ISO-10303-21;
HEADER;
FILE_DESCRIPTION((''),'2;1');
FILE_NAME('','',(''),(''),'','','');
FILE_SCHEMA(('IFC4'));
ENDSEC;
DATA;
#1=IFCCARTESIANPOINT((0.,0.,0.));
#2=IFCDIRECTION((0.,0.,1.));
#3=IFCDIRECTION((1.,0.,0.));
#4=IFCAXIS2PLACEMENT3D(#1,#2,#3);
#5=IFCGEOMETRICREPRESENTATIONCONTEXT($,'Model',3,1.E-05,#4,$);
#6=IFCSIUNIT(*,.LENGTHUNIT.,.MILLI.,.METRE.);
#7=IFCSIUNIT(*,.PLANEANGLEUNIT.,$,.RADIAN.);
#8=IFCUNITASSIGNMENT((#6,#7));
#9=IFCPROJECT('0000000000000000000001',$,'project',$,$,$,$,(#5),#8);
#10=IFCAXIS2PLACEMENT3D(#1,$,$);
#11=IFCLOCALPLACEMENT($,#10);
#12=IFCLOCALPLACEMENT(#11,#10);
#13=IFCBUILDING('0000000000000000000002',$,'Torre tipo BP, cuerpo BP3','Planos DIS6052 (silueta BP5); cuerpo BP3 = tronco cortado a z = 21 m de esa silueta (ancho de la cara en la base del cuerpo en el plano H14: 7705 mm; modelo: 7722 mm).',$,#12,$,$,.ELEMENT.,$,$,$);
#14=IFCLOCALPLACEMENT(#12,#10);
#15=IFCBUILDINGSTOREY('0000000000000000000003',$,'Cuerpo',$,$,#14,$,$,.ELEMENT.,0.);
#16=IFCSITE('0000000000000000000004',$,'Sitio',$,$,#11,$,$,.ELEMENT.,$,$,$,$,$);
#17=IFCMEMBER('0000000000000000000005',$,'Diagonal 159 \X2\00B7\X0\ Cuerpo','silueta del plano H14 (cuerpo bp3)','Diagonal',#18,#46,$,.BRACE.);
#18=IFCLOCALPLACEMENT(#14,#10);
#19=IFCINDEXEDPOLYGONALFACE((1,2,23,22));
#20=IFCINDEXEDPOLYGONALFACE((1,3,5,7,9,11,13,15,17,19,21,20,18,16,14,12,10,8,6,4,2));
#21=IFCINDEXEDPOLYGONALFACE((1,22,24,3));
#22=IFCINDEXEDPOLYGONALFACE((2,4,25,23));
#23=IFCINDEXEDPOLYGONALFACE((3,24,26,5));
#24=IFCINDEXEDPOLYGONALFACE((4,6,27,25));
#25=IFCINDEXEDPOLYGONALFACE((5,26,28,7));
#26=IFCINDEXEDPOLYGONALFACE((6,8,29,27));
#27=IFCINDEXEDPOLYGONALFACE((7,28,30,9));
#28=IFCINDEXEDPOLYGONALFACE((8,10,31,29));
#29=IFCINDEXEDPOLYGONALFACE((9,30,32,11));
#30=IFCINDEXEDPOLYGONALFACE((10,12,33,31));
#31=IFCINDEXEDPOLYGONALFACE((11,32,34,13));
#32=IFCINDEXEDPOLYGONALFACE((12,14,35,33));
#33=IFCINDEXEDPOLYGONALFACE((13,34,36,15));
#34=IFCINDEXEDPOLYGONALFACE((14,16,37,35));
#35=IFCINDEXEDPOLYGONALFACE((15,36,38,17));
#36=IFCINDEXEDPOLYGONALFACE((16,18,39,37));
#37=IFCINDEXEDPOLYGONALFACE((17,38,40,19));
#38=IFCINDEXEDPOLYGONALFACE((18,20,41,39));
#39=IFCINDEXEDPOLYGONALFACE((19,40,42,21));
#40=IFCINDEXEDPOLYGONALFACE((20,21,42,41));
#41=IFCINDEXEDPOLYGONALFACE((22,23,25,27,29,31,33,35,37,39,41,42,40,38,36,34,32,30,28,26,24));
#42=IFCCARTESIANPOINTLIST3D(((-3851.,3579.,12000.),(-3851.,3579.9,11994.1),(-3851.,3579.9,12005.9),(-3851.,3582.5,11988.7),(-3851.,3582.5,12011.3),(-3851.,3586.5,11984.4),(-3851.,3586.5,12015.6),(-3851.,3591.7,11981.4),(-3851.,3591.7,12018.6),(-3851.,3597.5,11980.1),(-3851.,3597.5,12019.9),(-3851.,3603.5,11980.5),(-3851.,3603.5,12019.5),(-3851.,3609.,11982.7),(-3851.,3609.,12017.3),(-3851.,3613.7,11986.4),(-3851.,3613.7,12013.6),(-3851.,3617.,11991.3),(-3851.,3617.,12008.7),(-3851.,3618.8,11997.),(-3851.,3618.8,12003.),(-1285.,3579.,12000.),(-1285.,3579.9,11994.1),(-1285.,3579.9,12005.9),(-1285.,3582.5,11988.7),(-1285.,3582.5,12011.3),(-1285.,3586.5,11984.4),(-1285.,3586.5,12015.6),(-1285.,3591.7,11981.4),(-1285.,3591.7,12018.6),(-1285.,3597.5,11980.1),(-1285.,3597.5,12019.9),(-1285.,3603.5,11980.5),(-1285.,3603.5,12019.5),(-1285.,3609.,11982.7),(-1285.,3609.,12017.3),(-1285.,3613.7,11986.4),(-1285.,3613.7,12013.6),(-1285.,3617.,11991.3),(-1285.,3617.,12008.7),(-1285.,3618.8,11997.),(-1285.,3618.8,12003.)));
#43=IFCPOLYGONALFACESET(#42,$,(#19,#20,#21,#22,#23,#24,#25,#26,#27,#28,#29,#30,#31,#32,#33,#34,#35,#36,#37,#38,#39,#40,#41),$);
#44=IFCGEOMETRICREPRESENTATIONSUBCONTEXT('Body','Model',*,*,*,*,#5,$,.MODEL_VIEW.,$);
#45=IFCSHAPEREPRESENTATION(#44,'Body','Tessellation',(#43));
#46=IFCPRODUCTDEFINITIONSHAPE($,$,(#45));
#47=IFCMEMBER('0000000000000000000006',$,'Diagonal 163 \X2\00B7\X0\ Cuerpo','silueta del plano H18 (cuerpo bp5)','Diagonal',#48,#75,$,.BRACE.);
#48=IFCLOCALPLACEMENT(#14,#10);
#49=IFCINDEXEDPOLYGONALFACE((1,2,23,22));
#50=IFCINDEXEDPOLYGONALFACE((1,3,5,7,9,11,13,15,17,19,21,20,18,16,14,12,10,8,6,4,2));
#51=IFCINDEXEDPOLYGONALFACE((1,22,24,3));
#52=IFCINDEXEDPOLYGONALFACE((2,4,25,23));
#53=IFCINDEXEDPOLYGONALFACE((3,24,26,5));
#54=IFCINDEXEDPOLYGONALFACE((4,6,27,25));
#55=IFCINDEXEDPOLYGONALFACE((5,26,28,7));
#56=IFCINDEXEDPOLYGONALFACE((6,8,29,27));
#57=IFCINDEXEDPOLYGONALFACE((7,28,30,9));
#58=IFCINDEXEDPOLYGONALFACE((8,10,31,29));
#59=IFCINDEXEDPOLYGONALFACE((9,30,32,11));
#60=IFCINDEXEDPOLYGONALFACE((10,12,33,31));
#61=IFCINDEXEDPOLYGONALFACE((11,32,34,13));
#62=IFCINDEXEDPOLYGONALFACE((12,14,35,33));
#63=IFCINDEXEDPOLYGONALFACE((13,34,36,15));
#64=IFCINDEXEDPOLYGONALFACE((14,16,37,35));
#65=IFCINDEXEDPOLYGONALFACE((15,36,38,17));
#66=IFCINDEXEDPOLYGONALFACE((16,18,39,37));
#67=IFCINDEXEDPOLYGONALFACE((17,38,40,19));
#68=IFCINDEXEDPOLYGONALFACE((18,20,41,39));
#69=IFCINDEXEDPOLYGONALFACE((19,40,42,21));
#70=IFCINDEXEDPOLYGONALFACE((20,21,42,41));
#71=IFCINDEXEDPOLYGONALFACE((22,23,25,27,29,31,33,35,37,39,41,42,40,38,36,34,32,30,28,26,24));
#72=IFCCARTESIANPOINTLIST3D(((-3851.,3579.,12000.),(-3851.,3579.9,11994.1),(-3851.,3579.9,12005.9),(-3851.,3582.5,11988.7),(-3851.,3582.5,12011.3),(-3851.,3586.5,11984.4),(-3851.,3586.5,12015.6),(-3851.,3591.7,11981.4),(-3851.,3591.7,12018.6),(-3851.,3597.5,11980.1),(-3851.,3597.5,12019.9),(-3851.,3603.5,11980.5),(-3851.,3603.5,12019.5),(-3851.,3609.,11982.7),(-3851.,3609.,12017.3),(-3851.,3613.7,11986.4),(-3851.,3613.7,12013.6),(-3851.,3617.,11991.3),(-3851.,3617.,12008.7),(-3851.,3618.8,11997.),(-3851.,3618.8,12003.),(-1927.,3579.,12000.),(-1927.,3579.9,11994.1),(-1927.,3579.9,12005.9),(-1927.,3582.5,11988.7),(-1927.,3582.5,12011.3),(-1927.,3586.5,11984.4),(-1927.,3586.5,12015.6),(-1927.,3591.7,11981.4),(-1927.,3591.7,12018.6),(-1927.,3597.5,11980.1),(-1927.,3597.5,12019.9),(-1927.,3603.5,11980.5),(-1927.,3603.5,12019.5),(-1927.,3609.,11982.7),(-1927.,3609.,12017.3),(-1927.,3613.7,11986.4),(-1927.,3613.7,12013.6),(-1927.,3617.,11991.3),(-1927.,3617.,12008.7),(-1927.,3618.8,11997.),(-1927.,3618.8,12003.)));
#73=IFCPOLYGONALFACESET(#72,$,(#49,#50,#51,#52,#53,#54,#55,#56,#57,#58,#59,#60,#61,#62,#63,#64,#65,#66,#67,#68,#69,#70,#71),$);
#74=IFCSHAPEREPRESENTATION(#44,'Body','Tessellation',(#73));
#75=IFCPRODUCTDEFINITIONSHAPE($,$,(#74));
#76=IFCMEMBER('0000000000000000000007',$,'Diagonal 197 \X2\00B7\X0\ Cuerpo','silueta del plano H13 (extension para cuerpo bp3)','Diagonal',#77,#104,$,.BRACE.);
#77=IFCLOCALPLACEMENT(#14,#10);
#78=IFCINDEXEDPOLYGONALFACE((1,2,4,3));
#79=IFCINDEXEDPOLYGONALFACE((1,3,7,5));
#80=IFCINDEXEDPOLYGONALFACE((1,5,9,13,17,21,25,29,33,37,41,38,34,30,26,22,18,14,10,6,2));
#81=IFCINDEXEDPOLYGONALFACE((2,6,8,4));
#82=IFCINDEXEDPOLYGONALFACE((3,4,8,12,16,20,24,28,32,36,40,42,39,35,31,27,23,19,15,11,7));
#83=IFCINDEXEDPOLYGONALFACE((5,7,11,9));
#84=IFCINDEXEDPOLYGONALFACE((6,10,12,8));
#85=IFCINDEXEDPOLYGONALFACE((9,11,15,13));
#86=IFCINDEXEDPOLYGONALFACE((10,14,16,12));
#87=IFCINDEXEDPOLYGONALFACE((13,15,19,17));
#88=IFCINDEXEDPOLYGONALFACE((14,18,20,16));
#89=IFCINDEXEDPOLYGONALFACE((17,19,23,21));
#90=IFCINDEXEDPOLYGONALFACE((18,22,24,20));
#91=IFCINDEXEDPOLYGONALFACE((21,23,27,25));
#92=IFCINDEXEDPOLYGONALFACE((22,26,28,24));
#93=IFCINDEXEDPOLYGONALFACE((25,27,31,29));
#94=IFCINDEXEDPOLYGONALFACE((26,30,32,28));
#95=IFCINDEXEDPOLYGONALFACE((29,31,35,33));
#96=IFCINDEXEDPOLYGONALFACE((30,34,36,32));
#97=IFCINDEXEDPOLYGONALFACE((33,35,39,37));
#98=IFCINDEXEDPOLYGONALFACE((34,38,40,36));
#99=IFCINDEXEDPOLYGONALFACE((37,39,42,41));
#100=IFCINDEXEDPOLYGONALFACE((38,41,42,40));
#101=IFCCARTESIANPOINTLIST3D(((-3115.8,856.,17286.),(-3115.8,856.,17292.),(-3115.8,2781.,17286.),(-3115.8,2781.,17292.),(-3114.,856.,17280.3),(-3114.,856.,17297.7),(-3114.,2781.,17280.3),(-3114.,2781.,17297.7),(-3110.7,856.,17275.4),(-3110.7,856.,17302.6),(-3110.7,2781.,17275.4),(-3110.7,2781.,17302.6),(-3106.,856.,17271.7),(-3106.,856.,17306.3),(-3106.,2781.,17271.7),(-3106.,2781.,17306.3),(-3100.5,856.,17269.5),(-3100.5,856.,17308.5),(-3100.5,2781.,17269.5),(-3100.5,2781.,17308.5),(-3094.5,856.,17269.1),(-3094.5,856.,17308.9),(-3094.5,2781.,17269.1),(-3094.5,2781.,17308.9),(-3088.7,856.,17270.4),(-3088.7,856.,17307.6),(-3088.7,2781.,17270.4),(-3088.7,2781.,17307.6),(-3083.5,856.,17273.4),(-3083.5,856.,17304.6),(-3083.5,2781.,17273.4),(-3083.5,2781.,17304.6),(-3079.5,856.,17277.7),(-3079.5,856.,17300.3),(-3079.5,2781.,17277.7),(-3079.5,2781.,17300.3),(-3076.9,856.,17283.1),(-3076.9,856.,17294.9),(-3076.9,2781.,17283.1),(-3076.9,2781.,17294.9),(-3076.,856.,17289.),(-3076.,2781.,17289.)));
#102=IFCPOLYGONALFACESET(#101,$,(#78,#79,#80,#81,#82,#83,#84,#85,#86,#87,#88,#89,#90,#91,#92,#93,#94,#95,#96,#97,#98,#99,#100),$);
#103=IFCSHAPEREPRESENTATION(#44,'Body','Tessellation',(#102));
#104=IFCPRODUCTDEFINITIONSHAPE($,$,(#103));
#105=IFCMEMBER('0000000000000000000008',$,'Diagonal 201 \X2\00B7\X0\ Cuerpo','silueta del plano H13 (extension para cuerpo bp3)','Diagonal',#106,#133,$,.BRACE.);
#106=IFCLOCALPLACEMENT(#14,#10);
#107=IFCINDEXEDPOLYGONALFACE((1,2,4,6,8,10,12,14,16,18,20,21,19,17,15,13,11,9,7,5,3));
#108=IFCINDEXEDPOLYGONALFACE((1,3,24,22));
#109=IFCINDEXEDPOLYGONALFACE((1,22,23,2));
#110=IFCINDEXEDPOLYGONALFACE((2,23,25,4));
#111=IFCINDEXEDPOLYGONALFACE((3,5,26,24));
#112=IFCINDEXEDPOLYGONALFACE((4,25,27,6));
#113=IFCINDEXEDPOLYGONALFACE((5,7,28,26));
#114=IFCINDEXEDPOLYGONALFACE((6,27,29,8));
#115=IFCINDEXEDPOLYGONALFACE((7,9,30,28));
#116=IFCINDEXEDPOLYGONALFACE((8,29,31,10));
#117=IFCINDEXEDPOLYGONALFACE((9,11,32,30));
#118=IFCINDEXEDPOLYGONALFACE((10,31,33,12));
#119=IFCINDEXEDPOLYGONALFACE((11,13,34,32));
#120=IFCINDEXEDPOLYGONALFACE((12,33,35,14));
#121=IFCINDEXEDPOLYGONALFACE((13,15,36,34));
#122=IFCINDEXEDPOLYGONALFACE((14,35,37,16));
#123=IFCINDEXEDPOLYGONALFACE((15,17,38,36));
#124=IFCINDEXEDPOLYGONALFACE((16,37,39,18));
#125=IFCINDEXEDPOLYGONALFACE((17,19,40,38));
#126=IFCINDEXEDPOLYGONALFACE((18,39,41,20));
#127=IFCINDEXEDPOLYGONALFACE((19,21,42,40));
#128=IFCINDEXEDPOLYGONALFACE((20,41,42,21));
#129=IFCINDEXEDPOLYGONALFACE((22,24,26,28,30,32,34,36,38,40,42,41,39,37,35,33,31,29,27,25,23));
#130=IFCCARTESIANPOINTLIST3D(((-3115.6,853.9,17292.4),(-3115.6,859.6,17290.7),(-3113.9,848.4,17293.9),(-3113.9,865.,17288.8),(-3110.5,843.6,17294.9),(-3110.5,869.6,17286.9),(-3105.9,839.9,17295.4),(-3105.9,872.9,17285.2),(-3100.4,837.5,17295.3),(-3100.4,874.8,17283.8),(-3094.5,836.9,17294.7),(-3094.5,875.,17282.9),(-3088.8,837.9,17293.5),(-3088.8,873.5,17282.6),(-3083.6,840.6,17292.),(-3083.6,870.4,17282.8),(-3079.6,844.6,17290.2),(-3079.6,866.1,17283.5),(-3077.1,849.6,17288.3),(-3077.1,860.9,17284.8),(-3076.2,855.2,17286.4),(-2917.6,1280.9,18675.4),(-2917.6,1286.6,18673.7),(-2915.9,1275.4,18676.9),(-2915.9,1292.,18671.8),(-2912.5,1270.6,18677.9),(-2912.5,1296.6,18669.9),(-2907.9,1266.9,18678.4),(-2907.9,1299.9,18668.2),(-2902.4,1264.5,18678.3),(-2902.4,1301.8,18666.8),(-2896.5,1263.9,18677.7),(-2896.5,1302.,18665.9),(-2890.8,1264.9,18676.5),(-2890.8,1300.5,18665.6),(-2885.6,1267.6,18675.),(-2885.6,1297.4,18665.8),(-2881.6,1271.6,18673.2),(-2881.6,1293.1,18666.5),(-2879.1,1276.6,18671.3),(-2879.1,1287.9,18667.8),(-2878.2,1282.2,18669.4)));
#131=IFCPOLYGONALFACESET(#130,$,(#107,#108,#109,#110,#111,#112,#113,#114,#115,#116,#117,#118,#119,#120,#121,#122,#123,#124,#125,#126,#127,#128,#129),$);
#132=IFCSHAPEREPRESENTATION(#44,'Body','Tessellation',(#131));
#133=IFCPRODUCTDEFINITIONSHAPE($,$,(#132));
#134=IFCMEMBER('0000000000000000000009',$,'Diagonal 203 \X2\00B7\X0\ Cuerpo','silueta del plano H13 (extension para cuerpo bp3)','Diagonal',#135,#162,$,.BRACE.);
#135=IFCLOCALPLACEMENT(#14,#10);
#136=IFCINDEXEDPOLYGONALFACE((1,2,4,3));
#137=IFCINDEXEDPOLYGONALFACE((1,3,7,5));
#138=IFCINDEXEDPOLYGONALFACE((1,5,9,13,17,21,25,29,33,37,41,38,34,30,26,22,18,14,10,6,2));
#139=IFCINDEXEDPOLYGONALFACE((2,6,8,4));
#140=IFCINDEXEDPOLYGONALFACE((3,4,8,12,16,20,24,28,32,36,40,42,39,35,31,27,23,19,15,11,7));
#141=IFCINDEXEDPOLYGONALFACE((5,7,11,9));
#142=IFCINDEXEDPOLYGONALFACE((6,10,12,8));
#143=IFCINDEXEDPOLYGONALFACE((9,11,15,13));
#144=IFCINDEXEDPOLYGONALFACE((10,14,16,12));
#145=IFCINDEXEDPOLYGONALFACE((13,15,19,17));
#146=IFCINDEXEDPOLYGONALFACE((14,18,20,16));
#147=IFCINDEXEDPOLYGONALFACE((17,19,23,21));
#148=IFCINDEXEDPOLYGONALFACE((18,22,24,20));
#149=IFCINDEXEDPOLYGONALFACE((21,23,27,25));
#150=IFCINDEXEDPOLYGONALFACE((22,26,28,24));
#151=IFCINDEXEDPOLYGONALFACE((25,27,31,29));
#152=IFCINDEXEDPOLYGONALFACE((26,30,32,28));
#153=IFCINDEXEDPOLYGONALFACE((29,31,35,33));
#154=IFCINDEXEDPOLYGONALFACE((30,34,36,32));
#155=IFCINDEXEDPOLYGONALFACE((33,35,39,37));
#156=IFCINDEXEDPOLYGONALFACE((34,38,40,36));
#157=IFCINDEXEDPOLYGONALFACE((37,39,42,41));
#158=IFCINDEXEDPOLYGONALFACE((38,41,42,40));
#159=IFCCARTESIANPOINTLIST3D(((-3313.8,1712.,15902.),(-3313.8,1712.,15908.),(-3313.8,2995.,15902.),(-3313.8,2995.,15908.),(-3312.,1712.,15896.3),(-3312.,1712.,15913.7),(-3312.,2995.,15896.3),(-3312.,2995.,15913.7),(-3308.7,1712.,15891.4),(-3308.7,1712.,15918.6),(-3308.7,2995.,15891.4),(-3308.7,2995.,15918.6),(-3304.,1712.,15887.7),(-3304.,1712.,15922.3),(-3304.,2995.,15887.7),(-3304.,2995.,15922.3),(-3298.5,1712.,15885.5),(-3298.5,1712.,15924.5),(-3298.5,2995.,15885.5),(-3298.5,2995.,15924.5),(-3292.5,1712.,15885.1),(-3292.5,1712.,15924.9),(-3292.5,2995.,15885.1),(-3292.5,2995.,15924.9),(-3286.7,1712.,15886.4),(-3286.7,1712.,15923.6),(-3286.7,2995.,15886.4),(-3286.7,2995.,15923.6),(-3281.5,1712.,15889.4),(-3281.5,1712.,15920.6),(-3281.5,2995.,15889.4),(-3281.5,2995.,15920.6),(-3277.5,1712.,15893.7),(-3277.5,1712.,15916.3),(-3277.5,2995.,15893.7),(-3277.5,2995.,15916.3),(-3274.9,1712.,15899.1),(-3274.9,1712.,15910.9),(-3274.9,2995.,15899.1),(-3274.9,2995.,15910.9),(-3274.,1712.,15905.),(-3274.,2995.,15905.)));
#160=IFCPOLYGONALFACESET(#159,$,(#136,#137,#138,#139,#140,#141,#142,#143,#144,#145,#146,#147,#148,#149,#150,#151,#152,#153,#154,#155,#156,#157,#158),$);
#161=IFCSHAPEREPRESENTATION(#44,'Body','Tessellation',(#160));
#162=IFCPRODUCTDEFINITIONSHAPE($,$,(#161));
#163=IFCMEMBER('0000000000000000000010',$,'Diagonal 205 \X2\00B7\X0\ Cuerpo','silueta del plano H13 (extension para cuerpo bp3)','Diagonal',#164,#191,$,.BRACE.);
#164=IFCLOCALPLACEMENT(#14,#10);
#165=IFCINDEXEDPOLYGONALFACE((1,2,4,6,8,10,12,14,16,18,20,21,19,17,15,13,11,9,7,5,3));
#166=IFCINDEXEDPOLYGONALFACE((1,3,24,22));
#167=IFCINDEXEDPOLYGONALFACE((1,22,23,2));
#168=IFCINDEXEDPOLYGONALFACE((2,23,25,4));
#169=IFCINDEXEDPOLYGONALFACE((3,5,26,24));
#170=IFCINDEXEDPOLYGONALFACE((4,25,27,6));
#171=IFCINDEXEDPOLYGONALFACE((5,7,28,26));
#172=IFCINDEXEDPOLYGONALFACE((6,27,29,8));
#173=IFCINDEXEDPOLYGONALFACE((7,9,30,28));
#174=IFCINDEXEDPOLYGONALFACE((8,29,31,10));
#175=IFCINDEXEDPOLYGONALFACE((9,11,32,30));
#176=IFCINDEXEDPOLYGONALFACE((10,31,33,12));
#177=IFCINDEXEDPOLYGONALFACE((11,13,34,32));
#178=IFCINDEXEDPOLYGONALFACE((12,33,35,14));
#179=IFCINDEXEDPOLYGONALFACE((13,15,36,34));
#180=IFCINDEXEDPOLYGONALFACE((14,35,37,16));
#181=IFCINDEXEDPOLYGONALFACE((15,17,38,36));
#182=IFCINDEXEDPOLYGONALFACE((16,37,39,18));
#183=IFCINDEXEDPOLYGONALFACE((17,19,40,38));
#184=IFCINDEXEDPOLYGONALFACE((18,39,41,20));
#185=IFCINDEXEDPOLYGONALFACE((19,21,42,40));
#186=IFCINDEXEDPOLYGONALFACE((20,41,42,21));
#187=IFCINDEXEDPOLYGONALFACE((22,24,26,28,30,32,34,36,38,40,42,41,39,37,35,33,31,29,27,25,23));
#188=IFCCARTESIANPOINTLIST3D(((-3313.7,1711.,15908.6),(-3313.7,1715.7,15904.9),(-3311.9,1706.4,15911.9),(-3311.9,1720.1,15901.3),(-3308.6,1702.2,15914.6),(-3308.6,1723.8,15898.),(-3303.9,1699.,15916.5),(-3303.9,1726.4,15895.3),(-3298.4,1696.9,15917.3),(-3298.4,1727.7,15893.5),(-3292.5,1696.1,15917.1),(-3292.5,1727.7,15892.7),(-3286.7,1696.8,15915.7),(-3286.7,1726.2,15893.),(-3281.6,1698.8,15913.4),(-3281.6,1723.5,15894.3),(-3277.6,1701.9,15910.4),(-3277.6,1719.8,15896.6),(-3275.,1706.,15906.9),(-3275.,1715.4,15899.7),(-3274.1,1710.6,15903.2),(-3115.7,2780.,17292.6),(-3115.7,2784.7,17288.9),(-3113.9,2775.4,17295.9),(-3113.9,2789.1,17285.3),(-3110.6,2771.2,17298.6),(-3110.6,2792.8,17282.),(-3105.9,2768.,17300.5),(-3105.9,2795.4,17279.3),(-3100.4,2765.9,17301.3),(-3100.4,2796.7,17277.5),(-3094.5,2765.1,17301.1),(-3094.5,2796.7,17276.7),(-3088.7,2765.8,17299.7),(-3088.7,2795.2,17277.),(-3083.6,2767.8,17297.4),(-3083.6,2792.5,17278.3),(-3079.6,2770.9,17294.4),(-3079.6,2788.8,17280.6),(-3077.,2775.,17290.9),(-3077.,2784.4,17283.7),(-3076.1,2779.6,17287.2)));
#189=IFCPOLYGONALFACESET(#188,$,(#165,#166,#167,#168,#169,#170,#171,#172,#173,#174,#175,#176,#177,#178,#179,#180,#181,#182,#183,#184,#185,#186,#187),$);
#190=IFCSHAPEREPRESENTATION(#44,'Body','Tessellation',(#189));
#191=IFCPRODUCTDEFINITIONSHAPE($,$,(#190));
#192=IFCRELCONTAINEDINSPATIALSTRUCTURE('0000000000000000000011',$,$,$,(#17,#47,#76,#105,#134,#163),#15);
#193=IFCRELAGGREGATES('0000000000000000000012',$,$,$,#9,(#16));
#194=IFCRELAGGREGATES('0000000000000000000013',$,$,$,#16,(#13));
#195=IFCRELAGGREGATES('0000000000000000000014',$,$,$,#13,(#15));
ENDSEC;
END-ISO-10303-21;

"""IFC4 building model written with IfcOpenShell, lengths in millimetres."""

from ifc_helpers import new_model, si_unit, frame, origin, origin_with_axes, place, context, subcontext, project, spatial, circle, extrude, element, save


model = new_model("IFC4")

# Units and contexts
model_context = context("Model", 3, precision=1e-05, world=origin_with_axes())
body_context = subcontext(model_context, "Body", "Model", "MODEL_VIEW")
ifc_project = project(units=[si_unit("LENGTHUNIT", "METRE", prefix="MILLI"), si_unit("PLANEANGLEUNIT", "RADIAN")], contexts=[model_context])

# Site, building, storey
site_placement = place(None, origin())
site = spatial("IfcSite", under=ifc_project, at=site_placement, Name="Sitio", CompositionType="ELEMENT")
building_placement = place(site_placement, origin())
building = spatial("IfcBuilding", under=site, at=building_placement, Name="Torre tipo BP, cuerpo BP3", Description="Planos DIS6052 (silueta BP5); cuerpo BP3 = tronco cortado a z = 21 m de esa silueta (ancho de la cara en la base del cuerpo en el plano H14: 7705 mm; modelo: 7722 mm).", CompositionType="ELEMENT")
storey_placement = place(building_placement, origin())
storey = spatial("IfcBuildingStorey", under=building, at=storey_placement, Name="Cuerpo", CompositionType="ELEMENT", Elevation=0.0)

# Members
member_1_placement = place(storey_placement, frame((-3851.0, 3599.0, 12000.0), z_axis=(1.0, 0.0, 0.0), x_axis=(0.0, -1.0, 0.0)))
element("IfcMember", 1, at=member_1_placement, inside=storey, Name="Diagonal 159 · Cuerpo", Description="silueta del plano H14 (cuerpo bp3)", ObjectType="Diagonal", PredefinedType="BRACE", context=body_context, shape_type="SweptSolid", body=[
    extrude(circle(Radius=20.0), None, (0.0, 0.0, 1.0), 2566.0),
])
member_2_placement = place(storey_placement, frame((-3851.0, 3599.0, 12000.0), z_axis=(1.0, 0.0, 0.0), x_axis=(0.0, -1.0, 0.0)))
element("IfcMember", 2, at=member_2_placement, inside=storey, Name="Diagonal 163 · Cuerpo", Description="silueta del plano H18 (cuerpo bp5)", ObjectType="Diagonal", PredefinedType="BRACE", context=body_context, shape_type="SweptSolid", body=[
    extrude(circle(Radius=20.0), None, (0.0, 0.0, 1.0), 1924.0),
])
member_3_placement = place(storey_placement, frame((-3096.0, 856.0, 17289.0), z_axis=(0.0, 1.0, 0.0), x_axis=(1.0, 0.0, 0.0)))
element("IfcMember", 3, at=member_3_placement, inside=storey, Name="Diagonal 197 · Cuerpo", Description="silueta del plano H13 (extension para cuerpo bp3)", ObjectType="Diagonal", PredefinedType="BRACE", context=body_context, shape_type="SweptSolid", body=[
    extrude(circle(Radius=20.0), None, (0.0, 0.0, 1.0), 1925.0),
])
member_4_placement = place(storey_placement, frame((-3096.0, 856.0, 17289.0), z_axis=(0.135533, 0.292286, 0.946678), x_axis=(0.990773, -0.039983, -0.129501)))
element("IfcMember", 4, at=member_4_placement, inside=storey, Name="Diagonal 201 · Cuerpo", Description="silueta del plano H13 (extension para cuerpo bp3)", ObjectType="Diagonal", PredefinedType="BRACE", context=body_context, shape_type="SweptSolid", body=[
    extrude(circle(Radius=20.0), None, (0.0, 0.0, 1.0), 1460.9),
])
member_5_placement = place(storey_placement, frame((-3294.0, 1712.0, 15905.0), z_axis=(0.0, 1.0, 0.0), x_axis=(1.0, 0.0, 0.0)))
element("IfcMember", 5, at=member_5_placement, inside=storey, Name="Diagonal 203 · Cuerpo", Description="silueta del plano H13 (extension para cuerpo bp3)", ObjectType="Diagonal", PredefinedType="BRACE", context=body_context, shape_type="SweptSolid", body=[
    extrude(circle(Radius=20.0), None, (0.0, 0.0, 1.0), 1283.0),
])
member_6_placement = place(storey_placement, frame((-3294.0, 1712.0, 15905.0), z_axis=(0.112503, 0.607404, 0.786386), x_axis=(0.993651, -0.068772, -0.089036)))
element("IfcMember", 6, at=member_6_placement, inside=storey, Name="Diagonal 205 · Cuerpo", Description="silueta del plano H13 (extension para cuerpo bp3)", ObjectType="Diagonal", PredefinedType="BRACE", context=body_context, shape_type="SweptSolid", body=[
    extrude(circle(Radius=20.0), None, (0.0, 0.0, 1.0), 1759.9),
])

save(model, "model.ifc")
